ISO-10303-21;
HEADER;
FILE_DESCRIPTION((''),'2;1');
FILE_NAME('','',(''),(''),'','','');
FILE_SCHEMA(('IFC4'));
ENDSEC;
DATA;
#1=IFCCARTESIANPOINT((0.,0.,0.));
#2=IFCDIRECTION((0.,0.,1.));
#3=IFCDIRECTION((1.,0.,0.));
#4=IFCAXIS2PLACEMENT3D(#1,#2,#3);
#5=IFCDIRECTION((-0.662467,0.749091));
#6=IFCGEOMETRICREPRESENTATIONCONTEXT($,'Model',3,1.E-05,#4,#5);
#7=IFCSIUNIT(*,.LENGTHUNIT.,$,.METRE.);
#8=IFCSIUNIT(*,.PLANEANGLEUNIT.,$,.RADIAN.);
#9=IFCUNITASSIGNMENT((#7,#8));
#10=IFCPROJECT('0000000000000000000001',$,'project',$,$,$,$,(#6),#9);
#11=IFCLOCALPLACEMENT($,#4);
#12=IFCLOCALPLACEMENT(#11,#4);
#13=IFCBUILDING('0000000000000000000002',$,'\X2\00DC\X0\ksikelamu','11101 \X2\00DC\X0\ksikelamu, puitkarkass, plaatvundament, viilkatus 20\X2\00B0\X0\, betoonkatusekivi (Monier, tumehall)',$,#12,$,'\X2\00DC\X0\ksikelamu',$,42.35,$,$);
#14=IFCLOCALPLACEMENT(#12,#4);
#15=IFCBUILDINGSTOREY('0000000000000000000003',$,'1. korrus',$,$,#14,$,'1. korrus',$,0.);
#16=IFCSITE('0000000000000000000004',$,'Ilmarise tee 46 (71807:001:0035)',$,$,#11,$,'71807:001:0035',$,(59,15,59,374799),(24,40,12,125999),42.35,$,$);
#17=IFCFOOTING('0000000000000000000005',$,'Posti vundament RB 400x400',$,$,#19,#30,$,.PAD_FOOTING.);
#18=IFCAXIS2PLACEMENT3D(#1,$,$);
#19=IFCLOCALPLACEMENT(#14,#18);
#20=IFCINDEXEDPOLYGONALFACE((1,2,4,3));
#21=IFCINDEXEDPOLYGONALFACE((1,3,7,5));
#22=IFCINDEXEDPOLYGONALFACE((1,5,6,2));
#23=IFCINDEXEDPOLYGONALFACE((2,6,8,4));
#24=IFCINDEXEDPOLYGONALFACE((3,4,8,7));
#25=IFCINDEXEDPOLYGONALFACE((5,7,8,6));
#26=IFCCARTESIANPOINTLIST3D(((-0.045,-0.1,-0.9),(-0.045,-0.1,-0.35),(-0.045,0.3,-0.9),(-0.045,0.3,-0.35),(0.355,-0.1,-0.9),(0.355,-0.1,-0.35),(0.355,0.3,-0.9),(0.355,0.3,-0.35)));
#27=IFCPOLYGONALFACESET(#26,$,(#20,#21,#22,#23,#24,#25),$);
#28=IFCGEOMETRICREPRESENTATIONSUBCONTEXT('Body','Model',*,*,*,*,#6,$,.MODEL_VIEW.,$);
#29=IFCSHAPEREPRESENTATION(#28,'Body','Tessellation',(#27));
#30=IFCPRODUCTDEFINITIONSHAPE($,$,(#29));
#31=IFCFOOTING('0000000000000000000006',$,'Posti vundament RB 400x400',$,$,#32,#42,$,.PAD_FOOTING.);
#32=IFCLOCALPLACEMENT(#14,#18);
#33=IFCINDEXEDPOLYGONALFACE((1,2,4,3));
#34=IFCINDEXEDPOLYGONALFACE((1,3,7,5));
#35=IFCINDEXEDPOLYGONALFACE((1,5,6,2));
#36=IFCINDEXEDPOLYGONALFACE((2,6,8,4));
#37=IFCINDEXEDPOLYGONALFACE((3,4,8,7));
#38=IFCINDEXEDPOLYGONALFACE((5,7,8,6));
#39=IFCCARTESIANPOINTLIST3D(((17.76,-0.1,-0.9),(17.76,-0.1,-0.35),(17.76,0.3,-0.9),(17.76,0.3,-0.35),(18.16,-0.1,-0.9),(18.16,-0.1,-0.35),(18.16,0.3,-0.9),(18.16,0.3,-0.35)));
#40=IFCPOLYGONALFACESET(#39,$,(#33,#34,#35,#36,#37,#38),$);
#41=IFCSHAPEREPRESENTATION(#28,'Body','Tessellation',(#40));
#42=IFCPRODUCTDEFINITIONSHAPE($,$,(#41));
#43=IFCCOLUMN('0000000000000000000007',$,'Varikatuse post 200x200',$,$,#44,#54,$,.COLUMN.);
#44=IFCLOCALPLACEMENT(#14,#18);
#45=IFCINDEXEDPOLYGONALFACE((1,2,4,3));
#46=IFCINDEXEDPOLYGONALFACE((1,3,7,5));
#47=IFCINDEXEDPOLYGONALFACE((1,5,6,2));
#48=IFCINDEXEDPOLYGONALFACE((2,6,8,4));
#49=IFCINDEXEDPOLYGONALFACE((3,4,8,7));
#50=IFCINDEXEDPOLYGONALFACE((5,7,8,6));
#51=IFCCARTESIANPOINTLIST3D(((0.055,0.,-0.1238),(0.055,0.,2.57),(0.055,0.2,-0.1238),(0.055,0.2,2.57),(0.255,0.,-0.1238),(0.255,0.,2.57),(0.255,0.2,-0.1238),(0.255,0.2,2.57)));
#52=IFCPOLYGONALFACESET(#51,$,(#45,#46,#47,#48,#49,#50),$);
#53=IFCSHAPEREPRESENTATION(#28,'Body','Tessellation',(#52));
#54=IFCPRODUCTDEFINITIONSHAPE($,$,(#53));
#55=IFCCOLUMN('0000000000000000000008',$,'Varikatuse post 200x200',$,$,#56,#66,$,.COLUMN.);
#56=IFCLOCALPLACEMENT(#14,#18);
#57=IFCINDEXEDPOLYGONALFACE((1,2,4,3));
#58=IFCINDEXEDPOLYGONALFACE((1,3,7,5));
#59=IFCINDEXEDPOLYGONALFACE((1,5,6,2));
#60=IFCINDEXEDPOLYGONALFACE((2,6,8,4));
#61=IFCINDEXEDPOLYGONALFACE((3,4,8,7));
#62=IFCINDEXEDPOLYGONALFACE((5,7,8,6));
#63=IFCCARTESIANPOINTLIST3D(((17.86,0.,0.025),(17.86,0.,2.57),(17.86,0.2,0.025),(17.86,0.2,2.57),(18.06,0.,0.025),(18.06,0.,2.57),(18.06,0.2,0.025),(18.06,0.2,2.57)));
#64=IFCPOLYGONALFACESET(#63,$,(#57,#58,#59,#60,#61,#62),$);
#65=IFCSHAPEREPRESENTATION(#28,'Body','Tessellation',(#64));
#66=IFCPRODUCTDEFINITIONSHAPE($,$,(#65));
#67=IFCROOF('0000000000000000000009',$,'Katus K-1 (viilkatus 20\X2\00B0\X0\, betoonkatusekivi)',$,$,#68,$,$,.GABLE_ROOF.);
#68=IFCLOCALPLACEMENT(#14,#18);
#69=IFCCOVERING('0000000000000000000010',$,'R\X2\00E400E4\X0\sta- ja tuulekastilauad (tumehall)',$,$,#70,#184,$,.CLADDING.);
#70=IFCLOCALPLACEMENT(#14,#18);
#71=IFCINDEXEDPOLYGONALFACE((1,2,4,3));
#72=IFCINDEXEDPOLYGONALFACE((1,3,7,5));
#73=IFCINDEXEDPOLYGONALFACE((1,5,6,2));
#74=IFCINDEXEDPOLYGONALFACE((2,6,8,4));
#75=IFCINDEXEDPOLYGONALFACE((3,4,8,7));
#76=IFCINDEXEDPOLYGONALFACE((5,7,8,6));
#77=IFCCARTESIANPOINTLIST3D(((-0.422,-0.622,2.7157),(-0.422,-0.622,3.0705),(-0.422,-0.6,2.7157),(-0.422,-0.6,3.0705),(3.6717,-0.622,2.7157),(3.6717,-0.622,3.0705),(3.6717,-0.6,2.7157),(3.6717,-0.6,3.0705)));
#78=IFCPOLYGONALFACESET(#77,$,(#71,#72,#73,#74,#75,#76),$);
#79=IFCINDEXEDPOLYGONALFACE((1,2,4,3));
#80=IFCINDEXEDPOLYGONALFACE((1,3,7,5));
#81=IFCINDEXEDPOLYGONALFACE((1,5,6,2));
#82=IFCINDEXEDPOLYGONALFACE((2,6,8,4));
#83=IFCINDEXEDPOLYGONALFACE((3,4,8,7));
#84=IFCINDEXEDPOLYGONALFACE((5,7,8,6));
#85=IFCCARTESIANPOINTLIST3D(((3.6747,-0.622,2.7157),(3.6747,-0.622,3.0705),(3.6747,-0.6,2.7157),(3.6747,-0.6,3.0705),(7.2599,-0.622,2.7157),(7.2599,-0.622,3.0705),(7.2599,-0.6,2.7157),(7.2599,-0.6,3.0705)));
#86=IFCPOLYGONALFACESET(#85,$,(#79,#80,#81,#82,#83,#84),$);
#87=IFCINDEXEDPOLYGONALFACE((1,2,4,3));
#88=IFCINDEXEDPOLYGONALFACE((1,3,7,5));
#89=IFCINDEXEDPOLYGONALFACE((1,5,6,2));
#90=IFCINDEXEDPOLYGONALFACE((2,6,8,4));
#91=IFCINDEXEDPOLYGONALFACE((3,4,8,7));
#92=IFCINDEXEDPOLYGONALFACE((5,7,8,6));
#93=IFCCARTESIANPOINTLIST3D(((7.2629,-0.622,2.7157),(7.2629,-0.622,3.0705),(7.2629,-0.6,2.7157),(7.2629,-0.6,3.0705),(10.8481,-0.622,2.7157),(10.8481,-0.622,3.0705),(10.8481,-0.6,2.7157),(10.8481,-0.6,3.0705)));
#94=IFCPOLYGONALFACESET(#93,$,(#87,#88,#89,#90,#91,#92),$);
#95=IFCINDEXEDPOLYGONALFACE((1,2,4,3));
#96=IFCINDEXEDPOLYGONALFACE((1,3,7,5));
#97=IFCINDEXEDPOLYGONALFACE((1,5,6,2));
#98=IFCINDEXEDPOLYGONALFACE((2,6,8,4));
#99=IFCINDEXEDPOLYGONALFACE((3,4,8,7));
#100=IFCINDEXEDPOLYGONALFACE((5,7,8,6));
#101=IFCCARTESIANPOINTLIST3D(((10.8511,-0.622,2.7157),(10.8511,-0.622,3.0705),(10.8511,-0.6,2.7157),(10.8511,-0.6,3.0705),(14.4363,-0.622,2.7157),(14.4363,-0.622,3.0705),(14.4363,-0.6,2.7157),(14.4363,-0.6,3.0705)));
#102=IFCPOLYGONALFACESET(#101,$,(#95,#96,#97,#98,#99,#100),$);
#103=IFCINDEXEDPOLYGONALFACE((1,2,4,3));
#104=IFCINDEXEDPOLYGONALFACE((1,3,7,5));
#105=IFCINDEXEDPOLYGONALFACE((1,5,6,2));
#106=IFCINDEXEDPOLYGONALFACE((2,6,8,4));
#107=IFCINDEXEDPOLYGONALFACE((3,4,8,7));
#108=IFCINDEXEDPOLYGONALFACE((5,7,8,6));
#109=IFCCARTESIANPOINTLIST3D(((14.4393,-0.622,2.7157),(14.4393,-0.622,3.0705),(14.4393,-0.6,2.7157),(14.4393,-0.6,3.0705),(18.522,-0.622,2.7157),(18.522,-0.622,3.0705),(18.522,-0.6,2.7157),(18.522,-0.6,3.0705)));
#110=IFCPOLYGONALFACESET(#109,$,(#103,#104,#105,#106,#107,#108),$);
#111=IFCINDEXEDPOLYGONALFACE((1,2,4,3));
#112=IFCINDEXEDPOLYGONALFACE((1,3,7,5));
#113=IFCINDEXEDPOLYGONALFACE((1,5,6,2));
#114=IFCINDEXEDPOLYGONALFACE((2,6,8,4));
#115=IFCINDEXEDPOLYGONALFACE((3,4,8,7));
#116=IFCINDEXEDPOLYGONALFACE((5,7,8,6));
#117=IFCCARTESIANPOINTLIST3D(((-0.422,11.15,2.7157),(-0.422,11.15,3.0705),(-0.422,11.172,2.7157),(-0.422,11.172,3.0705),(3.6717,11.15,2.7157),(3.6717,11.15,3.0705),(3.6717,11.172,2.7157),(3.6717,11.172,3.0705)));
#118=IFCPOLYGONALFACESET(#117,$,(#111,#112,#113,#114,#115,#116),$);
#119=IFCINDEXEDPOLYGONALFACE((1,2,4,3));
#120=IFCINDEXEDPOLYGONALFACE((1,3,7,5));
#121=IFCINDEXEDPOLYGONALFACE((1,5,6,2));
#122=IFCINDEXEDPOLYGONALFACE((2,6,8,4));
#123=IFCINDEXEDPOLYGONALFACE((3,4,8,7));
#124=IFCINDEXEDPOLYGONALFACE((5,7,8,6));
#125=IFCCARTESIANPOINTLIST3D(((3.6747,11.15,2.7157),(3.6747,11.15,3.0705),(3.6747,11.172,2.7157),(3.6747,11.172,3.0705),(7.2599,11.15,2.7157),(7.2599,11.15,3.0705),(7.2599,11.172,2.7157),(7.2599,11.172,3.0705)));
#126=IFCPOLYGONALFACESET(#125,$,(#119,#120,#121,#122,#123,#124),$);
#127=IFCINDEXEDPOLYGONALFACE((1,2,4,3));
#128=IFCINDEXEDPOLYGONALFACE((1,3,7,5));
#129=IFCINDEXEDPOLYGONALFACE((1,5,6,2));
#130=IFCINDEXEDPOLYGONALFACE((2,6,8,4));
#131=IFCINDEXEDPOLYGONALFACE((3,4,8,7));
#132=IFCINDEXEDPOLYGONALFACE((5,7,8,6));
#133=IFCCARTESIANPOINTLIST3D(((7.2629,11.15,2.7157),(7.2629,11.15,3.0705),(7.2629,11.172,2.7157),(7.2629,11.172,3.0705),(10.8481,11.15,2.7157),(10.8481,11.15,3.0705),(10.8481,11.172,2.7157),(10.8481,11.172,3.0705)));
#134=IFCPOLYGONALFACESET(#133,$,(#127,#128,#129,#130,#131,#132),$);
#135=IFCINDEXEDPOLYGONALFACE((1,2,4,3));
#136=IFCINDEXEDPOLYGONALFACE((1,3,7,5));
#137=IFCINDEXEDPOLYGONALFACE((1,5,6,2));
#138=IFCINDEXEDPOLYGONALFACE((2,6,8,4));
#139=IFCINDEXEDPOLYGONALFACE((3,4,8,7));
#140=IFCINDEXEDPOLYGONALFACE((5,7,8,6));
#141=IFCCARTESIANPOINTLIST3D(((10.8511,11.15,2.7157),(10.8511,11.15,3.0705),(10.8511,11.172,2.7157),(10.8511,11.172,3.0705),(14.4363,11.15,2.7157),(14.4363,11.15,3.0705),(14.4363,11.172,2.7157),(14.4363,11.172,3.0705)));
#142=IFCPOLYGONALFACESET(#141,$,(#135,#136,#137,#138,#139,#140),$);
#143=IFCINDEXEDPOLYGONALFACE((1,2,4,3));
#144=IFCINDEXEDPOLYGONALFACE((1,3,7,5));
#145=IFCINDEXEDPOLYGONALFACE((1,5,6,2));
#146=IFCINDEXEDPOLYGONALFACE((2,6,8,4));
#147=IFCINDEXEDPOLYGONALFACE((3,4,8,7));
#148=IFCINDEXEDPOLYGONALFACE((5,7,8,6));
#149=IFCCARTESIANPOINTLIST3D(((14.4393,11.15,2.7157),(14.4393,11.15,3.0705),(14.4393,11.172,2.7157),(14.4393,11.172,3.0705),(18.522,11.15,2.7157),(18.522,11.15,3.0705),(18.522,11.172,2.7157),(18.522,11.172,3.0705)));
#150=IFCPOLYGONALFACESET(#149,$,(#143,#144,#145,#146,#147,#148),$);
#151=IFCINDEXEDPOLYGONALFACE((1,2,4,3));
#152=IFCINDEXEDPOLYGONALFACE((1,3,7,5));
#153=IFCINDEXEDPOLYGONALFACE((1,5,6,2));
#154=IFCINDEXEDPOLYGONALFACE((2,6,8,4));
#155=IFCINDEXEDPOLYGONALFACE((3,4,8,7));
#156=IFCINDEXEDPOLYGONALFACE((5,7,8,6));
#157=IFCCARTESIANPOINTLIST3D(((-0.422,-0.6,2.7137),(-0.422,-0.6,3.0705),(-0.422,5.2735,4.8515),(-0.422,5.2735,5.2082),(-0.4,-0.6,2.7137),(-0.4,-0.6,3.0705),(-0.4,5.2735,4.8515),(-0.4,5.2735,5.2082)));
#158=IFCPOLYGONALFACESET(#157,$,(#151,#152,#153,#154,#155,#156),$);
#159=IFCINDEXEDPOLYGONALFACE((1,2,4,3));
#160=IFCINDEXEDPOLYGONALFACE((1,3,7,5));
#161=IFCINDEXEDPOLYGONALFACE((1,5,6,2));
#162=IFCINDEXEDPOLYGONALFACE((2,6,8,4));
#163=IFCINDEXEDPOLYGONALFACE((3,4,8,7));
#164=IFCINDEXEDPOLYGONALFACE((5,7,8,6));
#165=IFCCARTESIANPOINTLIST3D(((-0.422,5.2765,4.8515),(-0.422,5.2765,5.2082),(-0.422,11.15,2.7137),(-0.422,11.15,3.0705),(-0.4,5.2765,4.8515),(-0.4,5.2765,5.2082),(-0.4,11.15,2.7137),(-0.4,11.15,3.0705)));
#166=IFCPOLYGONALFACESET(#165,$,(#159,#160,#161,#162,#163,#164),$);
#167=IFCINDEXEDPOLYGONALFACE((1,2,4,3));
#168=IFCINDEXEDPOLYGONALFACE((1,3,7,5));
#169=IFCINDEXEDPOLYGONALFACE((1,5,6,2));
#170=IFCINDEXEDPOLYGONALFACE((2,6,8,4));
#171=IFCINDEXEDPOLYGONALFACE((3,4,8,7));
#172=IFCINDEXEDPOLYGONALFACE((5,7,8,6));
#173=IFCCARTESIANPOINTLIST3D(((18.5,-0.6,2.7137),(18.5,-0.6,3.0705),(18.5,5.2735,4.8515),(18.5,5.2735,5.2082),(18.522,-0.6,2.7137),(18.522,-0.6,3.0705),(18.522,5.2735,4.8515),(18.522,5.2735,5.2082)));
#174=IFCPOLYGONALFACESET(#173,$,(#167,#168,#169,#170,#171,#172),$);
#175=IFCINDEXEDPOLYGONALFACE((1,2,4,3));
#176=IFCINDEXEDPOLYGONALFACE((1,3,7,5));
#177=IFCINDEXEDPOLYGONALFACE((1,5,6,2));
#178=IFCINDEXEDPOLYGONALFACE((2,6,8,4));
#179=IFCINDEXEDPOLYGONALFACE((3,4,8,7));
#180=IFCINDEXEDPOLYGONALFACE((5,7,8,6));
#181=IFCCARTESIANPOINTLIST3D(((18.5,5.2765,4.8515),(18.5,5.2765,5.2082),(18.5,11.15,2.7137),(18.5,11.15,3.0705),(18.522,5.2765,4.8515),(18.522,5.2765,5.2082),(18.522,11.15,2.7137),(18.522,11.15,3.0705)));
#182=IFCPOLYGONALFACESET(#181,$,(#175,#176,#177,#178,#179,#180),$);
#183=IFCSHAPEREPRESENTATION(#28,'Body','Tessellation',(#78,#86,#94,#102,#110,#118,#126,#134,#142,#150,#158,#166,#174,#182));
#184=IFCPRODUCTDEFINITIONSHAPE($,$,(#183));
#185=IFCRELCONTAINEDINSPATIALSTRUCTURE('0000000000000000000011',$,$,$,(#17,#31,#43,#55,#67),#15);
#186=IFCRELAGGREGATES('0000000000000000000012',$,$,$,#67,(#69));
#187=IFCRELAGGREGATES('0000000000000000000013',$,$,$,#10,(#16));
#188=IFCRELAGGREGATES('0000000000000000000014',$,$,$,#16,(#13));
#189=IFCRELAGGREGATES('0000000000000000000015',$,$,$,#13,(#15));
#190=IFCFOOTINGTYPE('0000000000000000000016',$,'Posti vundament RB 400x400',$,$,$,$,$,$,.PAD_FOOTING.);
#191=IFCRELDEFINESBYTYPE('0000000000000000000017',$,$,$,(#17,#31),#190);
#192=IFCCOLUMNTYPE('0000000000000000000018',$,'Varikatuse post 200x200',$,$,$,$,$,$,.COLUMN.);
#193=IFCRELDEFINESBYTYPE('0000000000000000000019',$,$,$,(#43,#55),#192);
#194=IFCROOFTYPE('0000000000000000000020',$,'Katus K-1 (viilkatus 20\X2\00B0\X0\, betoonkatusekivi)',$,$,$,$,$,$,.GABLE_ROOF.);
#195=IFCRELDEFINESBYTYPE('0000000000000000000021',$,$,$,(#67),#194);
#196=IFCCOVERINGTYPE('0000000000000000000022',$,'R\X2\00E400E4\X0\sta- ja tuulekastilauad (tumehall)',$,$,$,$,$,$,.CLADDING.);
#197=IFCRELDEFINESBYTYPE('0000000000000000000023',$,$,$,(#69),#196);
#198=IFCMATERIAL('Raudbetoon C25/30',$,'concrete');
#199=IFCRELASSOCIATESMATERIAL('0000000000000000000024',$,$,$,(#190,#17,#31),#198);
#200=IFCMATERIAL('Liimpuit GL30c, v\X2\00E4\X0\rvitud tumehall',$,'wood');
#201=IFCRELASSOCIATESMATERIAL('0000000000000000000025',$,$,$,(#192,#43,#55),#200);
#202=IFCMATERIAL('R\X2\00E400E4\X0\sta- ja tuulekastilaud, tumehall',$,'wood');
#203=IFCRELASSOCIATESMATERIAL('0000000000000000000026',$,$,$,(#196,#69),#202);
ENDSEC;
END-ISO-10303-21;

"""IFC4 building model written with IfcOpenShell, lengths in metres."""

from ifc_helpers import new_model, si_unit, direction, frame, origin_with_axes, place, context, subcontext, project, spatial, indexed_curve, outline, extrude, material, type_object, element, aggregate, save


model = new_model("IFC4")

# Units and contexts
model_context = context("Model", 3, precision=1e-05, world=origin_with_axes(), true_north=direction((-0.662467, 0.749091)))
body_context = subcontext(model_context, "Body", "Model", "MODEL_VIEW")
ifc_project = project(units=[si_unit("LENGTHUNIT", "METRE"), si_unit("PLANEANGLEUNIT", "RADIAN")], contexts=[model_context])

# Site, building, storey
site_placement = place(None, origin_with_axes())
site = spatial("IfcSite", under=ifc_project, at=site_placement, Name="Ilmarise tee 46 (71807:001:0035)", LongName="71807:001:0035", RefLatitude=(59, 15, 59, 374799), RefLongitude=(24, 40, 12, 125999), RefElevation=42.35)
building_placement = place(site_placement, origin_with_axes())
building = spatial("IfcBuilding", under=site, at=building_placement, Name="Üksikelamu", Description="11101 Üksikelamu, puitkarkass, plaatvundament, viilkatus 20°, betoonkatusekivi (Monier, tumehall)", LongName="Üksikelamu", ElevationOfRefHeight=42.35)
storey_placement = place(building_placement, origin_with_axes())
storey = spatial("IfcBuildingStorey", under=building, at=storey_placement, Name="1. korrus", LongName="1. korrus", Elevation=0.0)

# Footings
ifc_material_1 = material(Name="Raudbetoon C25/30", Category="concrete")
footing_type = type_object("IfcFootingType", Name="Posti vundament RB 400x400", PredefinedType="PAD_FOOTING", material=ifc_material_1)
footing_1_placement = place(storey_placement, origin_with_axes())
element("IfcFooting", 1, at=footing_1_placement, inside=storey, type_object=footing_type, material=ifc_material_1, Name="Posti vundament RB 400x400", PredefinedType="PAD_FOOTING", context=body_context, shape_type="SweptSolid", body=[
    extrude(outline(indexed_curve([(-0.045, -0.1), (0.355, -0.1), (0.355, 0.3), (-0.045, 0.3), (-0.045, -0.1)], self_intersect=False)), frame((0.0, 0.0, -0.9), z_axis=(0.0, 0.0, 1.0), x_axis=(1.0, 0.0, 0.0)), (0.0, 0.0, 1.0), 0.55),
])
footing_2_placement = place(storey_placement, origin_with_axes())
element("IfcFooting", 2, at=footing_2_placement, inside=storey, type_object=footing_type, material=ifc_material_1, Name="Posti vundament RB 400x400", PredefinedType="PAD_FOOTING", context=body_context, shape_type="SweptSolid", body=[
    extrude(outline(indexed_curve([(17.76, -0.1), (18.16, -0.1), (18.16, 0.3), (17.76, 0.3), (17.76, -0.1)], self_intersect=False)), frame((0.0, 0.0, -0.9), z_axis=(0.0, 0.0, 1.0), x_axis=(1.0, 0.0, 0.0)), (0.0, 0.0, 1.0), 0.55),
])

# Columns
ifc_material_2 = material(Name="Liimpuit GL30c, värvitud tumehall", Category="wood")
column_type = type_object("IfcColumnType", Name="Varikatuse post 200x200", PredefinedType="COLUMN", material=ifc_material_2)
column_1_placement = place(storey_placement, origin_with_axes())
element("IfcColumn", 3, at=column_1_placement, inside=storey, type_object=column_type, material=ifc_material_2, Name="Varikatuse post 200x200", PredefinedType="COLUMN", context=body_context, shape_type="SweptSolid", body=[
    extrude(outline(indexed_curve([(0.055, 0.0), (0.255, 0.0), (0.255, 0.2), (0.055, 0.2), (0.055, 0.0)], self_intersect=False)), frame((0.0, 0.0, -0.1238), z_axis=(0.0, 0.0, 1.0), x_axis=(1.0, 0.0, 0.0)), (0.0, 0.0, 1.0), 2.6938),
])
column_2_placement = place(storey_placement, origin_with_axes())
element("IfcColumn", 4, at=column_2_placement, inside=storey, type_object=column_type, material=ifc_material_2, Name="Varikatuse post 200x200", PredefinedType="COLUMN", context=body_context, shape_type="SweptSolid", body=[
    extrude(outline(indexed_curve([(17.86, 0.0), (18.06, 0.0), (18.06, 0.2), (17.86, 0.2), (17.86, 0.0)], self_intersect=False)), frame((0.0, 0.0, 0.025), z_axis=(0.0, 0.0, 1.0), x_axis=(1.0, 0.0, 0.0)), (0.0, 0.0, 1.0), 2.545),
])

# Roof, covering
roof_type = type_object("IfcRoofType", Name="Katus K-1 (viilkatus 20°, betoonkatusekivi)", PredefinedType="GABLE_ROOF")
roof_placement = place(storey_placement, origin_with_axes())
roof = element("IfcRoof", 5, at=roof_placement, inside=storey, type_object=roof_type, Name="Katus K-1 (viilkatus 20°, betoonkatusekivi)", PredefinedType="GABLE_ROOF")
ifc_material_3 = material(Name="Räästa- ja tuulekastilaud, tumehall", Category="wood")
covering_type_1 = type_object("IfcCoveringType", Name="Räästa- ja tuulekastilauad (tumehall)", PredefinedType="CLADDING", material=ifc_material_3)
covering_1_placement = place(roof_placement, origin_with_axes())
covering_1 = element("IfcCovering", 6, at=covering_1_placement, type_object=covering_type_1, material=ifc_material_3, Name="Räästa- ja tuulekastilauad (tumehall)", PredefinedType="CLADDING", context=body_context, shape_type="SweptSolid", body=[
    extrude(outline(indexed_curve([(-0.422, -0.622), (3.6717, -0.622), (3.6717, -0.6), (-0.422, -0.6), (-0.422, -0.622)], self_intersect=False)), frame((0.0, 0.0, 2.7157), z_axis=(0.0, 0.0, 1.0), x_axis=(1.0, 0.0, 0.0)), (0.0, 0.0, 1.0), 0.3548),
    extrude(outline(indexed_curve([(3.6747, -0.622), (7.2599, -0.622), (7.2599, -0.6), (3.6747, -0.6), (3.6747, -0.622)], self_intersect=False)), frame((0.0, 0.0, 2.7157), z_axis=(0.0, 0.0, 1.0), x_axis=(1.0, 0.0, 0.0)), (0.0, 0.0, 1.0), 0.3548),
    extrude(outline(indexed_curve([(7.2629, -0.622), (10.8481, -0.622), (10.8481, -0.6), (7.2629, -0.6), (7.2629, -0.622)], self_intersect=False)), frame((0.0, 0.0, 2.7157), z_axis=(0.0, 0.0, 1.0), x_axis=(1.0, 0.0, 0.0)), (0.0, 0.0, 1.0), 0.3548),
    extrude(outline(indexed_curve([(10.8511, -0.622), (14.4363, -0.622), (14.4363, -0.6), (10.8511, -0.6), (10.8511, -0.622)], self_intersect=False)), frame((0.0, 0.0, 2.7157), z_axis=(0.0, 0.0, 1.0), x_axis=(1.0, 0.0, 0.0)), (0.0, 0.0, 1.0), 0.3548),
    extrude(outline(indexed_curve([(14.4393, -0.622), (18.522, -0.622), (18.522, -0.6), (14.4393, -0.6), (14.4393, -0.622)], self_intersect=False)), frame((0.0, 0.0, 2.7157), z_axis=(0.0, 0.0, 1.0), x_axis=(1.0, 0.0, 0.0)), (0.0, 0.0, 1.0), 0.3548),
    extrude(outline(indexed_curve([(-0.422, 11.15), (3.6717, 11.15), (3.6717, 11.172), (-0.422, 11.172), (-0.422, 11.15)], self_intersect=False)), frame((0.0, 0.0, 2.7157), z_axis=(0.0, 0.0, 1.0), x_axis=(1.0, 0.0, 0.0)), (0.0, 0.0, 1.0), 0.3548),
    extrude(outline(indexed_curve([(3.6747, 11.15), (7.2599, 11.15), (7.2599, 11.172), (3.6747, 11.172), (3.6747, 11.15)], self_intersect=False)), frame((0.0, 0.0, 2.7157), z_axis=(0.0, 0.0, 1.0), x_axis=(1.0, 0.0, 0.0)), (0.0, 0.0, 1.0), 0.3548),
    extrude(outline(indexed_curve([(7.2629, 11.15), (10.8481, 11.15), (10.8481, 11.172), (7.2629, 11.172), (7.2629, 11.15)], self_intersect=False)), frame((0.0, 0.0, 2.7157), z_axis=(0.0, 0.0, 1.0), x_axis=(1.0, 0.0, 0.0)), (0.0, 0.0, 1.0), 0.3548),
    extrude(outline(indexed_curve([(10.8511, 11.15), (14.4363, 11.15), (14.4363, 11.172), (10.8511, 11.172), (10.8511, 11.15)], self_intersect=False)), frame((0.0, 0.0, 2.7157), z_axis=(0.0, 0.0, 1.0), x_axis=(1.0, 0.0, 0.0)), (0.0, 0.0, 1.0), 0.3548),
    extrude(outline(indexed_curve([(14.4393, 11.15), (18.522, 11.15), (18.522, 11.172), (14.4393, 11.172), (14.4393, 11.15)], self_intersect=False)), frame((0.0, 0.0, 2.7157), z_axis=(0.0, 0.0, 1.0), x_axis=(1.0, 0.0, 0.0)), (0.0, 0.0, 1.0), 0.3548),
    extrude(outline(indexed_curve([(-0.6, 2.7137), (5.2735, 4.8515), (5.2735, 5.2082), (-0.6, 3.0705), (-0.6, 2.7137)], self_intersect=False)), frame((-0.422, 0.0, 0.0), z_axis=(1.0, 0.0, 0.0), x_axis=(0.0, 1.0, 0.0)), (0.0, 0.0, 1.0), 0.022),
    extrude(outline(indexed_curve([(5.2765, 4.8515), (11.15, 2.7137), (11.15, 3.0705), (5.2765, 5.2082), (5.2765, 4.8515)], self_intersect=False)), frame((-0.422, 0.0, 0.0), z_axis=(1.0, 0.0, 0.0), x_axis=(0.0, 1.0, 0.0)), (0.0, 0.0, 1.0), 0.022),
    extrude(outline(indexed_curve([(-0.6, 2.7137), (5.2735, 4.8515), (5.2735, 5.2082), (-0.6, 3.0705), (-0.6, 2.7137)], self_intersect=False)), frame((18.5, 0.0, 0.0), z_axis=(1.0, 0.0, 0.0), x_axis=(0.0, 1.0, 0.0)), (0.0, 0.0, 1.0), 0.022),
    extrude(outline(indexed_curve([(5.2765, 4.8515), (11.15, 2.7137), (11.15, 3.0705), (5.2765, 5.2082), (5.2765, 4.8515)], self_intersect=False)), frame((18.5, 0.0, 0.0), z_axis=(1.0, 0.0, 0.0), x_axis=(0.0, 1.0, 0.0)), (0.0, 0.0, 1.0), 0.022),
])

aggregate(roof, [covering_1])

save(model, "model.ifc")
